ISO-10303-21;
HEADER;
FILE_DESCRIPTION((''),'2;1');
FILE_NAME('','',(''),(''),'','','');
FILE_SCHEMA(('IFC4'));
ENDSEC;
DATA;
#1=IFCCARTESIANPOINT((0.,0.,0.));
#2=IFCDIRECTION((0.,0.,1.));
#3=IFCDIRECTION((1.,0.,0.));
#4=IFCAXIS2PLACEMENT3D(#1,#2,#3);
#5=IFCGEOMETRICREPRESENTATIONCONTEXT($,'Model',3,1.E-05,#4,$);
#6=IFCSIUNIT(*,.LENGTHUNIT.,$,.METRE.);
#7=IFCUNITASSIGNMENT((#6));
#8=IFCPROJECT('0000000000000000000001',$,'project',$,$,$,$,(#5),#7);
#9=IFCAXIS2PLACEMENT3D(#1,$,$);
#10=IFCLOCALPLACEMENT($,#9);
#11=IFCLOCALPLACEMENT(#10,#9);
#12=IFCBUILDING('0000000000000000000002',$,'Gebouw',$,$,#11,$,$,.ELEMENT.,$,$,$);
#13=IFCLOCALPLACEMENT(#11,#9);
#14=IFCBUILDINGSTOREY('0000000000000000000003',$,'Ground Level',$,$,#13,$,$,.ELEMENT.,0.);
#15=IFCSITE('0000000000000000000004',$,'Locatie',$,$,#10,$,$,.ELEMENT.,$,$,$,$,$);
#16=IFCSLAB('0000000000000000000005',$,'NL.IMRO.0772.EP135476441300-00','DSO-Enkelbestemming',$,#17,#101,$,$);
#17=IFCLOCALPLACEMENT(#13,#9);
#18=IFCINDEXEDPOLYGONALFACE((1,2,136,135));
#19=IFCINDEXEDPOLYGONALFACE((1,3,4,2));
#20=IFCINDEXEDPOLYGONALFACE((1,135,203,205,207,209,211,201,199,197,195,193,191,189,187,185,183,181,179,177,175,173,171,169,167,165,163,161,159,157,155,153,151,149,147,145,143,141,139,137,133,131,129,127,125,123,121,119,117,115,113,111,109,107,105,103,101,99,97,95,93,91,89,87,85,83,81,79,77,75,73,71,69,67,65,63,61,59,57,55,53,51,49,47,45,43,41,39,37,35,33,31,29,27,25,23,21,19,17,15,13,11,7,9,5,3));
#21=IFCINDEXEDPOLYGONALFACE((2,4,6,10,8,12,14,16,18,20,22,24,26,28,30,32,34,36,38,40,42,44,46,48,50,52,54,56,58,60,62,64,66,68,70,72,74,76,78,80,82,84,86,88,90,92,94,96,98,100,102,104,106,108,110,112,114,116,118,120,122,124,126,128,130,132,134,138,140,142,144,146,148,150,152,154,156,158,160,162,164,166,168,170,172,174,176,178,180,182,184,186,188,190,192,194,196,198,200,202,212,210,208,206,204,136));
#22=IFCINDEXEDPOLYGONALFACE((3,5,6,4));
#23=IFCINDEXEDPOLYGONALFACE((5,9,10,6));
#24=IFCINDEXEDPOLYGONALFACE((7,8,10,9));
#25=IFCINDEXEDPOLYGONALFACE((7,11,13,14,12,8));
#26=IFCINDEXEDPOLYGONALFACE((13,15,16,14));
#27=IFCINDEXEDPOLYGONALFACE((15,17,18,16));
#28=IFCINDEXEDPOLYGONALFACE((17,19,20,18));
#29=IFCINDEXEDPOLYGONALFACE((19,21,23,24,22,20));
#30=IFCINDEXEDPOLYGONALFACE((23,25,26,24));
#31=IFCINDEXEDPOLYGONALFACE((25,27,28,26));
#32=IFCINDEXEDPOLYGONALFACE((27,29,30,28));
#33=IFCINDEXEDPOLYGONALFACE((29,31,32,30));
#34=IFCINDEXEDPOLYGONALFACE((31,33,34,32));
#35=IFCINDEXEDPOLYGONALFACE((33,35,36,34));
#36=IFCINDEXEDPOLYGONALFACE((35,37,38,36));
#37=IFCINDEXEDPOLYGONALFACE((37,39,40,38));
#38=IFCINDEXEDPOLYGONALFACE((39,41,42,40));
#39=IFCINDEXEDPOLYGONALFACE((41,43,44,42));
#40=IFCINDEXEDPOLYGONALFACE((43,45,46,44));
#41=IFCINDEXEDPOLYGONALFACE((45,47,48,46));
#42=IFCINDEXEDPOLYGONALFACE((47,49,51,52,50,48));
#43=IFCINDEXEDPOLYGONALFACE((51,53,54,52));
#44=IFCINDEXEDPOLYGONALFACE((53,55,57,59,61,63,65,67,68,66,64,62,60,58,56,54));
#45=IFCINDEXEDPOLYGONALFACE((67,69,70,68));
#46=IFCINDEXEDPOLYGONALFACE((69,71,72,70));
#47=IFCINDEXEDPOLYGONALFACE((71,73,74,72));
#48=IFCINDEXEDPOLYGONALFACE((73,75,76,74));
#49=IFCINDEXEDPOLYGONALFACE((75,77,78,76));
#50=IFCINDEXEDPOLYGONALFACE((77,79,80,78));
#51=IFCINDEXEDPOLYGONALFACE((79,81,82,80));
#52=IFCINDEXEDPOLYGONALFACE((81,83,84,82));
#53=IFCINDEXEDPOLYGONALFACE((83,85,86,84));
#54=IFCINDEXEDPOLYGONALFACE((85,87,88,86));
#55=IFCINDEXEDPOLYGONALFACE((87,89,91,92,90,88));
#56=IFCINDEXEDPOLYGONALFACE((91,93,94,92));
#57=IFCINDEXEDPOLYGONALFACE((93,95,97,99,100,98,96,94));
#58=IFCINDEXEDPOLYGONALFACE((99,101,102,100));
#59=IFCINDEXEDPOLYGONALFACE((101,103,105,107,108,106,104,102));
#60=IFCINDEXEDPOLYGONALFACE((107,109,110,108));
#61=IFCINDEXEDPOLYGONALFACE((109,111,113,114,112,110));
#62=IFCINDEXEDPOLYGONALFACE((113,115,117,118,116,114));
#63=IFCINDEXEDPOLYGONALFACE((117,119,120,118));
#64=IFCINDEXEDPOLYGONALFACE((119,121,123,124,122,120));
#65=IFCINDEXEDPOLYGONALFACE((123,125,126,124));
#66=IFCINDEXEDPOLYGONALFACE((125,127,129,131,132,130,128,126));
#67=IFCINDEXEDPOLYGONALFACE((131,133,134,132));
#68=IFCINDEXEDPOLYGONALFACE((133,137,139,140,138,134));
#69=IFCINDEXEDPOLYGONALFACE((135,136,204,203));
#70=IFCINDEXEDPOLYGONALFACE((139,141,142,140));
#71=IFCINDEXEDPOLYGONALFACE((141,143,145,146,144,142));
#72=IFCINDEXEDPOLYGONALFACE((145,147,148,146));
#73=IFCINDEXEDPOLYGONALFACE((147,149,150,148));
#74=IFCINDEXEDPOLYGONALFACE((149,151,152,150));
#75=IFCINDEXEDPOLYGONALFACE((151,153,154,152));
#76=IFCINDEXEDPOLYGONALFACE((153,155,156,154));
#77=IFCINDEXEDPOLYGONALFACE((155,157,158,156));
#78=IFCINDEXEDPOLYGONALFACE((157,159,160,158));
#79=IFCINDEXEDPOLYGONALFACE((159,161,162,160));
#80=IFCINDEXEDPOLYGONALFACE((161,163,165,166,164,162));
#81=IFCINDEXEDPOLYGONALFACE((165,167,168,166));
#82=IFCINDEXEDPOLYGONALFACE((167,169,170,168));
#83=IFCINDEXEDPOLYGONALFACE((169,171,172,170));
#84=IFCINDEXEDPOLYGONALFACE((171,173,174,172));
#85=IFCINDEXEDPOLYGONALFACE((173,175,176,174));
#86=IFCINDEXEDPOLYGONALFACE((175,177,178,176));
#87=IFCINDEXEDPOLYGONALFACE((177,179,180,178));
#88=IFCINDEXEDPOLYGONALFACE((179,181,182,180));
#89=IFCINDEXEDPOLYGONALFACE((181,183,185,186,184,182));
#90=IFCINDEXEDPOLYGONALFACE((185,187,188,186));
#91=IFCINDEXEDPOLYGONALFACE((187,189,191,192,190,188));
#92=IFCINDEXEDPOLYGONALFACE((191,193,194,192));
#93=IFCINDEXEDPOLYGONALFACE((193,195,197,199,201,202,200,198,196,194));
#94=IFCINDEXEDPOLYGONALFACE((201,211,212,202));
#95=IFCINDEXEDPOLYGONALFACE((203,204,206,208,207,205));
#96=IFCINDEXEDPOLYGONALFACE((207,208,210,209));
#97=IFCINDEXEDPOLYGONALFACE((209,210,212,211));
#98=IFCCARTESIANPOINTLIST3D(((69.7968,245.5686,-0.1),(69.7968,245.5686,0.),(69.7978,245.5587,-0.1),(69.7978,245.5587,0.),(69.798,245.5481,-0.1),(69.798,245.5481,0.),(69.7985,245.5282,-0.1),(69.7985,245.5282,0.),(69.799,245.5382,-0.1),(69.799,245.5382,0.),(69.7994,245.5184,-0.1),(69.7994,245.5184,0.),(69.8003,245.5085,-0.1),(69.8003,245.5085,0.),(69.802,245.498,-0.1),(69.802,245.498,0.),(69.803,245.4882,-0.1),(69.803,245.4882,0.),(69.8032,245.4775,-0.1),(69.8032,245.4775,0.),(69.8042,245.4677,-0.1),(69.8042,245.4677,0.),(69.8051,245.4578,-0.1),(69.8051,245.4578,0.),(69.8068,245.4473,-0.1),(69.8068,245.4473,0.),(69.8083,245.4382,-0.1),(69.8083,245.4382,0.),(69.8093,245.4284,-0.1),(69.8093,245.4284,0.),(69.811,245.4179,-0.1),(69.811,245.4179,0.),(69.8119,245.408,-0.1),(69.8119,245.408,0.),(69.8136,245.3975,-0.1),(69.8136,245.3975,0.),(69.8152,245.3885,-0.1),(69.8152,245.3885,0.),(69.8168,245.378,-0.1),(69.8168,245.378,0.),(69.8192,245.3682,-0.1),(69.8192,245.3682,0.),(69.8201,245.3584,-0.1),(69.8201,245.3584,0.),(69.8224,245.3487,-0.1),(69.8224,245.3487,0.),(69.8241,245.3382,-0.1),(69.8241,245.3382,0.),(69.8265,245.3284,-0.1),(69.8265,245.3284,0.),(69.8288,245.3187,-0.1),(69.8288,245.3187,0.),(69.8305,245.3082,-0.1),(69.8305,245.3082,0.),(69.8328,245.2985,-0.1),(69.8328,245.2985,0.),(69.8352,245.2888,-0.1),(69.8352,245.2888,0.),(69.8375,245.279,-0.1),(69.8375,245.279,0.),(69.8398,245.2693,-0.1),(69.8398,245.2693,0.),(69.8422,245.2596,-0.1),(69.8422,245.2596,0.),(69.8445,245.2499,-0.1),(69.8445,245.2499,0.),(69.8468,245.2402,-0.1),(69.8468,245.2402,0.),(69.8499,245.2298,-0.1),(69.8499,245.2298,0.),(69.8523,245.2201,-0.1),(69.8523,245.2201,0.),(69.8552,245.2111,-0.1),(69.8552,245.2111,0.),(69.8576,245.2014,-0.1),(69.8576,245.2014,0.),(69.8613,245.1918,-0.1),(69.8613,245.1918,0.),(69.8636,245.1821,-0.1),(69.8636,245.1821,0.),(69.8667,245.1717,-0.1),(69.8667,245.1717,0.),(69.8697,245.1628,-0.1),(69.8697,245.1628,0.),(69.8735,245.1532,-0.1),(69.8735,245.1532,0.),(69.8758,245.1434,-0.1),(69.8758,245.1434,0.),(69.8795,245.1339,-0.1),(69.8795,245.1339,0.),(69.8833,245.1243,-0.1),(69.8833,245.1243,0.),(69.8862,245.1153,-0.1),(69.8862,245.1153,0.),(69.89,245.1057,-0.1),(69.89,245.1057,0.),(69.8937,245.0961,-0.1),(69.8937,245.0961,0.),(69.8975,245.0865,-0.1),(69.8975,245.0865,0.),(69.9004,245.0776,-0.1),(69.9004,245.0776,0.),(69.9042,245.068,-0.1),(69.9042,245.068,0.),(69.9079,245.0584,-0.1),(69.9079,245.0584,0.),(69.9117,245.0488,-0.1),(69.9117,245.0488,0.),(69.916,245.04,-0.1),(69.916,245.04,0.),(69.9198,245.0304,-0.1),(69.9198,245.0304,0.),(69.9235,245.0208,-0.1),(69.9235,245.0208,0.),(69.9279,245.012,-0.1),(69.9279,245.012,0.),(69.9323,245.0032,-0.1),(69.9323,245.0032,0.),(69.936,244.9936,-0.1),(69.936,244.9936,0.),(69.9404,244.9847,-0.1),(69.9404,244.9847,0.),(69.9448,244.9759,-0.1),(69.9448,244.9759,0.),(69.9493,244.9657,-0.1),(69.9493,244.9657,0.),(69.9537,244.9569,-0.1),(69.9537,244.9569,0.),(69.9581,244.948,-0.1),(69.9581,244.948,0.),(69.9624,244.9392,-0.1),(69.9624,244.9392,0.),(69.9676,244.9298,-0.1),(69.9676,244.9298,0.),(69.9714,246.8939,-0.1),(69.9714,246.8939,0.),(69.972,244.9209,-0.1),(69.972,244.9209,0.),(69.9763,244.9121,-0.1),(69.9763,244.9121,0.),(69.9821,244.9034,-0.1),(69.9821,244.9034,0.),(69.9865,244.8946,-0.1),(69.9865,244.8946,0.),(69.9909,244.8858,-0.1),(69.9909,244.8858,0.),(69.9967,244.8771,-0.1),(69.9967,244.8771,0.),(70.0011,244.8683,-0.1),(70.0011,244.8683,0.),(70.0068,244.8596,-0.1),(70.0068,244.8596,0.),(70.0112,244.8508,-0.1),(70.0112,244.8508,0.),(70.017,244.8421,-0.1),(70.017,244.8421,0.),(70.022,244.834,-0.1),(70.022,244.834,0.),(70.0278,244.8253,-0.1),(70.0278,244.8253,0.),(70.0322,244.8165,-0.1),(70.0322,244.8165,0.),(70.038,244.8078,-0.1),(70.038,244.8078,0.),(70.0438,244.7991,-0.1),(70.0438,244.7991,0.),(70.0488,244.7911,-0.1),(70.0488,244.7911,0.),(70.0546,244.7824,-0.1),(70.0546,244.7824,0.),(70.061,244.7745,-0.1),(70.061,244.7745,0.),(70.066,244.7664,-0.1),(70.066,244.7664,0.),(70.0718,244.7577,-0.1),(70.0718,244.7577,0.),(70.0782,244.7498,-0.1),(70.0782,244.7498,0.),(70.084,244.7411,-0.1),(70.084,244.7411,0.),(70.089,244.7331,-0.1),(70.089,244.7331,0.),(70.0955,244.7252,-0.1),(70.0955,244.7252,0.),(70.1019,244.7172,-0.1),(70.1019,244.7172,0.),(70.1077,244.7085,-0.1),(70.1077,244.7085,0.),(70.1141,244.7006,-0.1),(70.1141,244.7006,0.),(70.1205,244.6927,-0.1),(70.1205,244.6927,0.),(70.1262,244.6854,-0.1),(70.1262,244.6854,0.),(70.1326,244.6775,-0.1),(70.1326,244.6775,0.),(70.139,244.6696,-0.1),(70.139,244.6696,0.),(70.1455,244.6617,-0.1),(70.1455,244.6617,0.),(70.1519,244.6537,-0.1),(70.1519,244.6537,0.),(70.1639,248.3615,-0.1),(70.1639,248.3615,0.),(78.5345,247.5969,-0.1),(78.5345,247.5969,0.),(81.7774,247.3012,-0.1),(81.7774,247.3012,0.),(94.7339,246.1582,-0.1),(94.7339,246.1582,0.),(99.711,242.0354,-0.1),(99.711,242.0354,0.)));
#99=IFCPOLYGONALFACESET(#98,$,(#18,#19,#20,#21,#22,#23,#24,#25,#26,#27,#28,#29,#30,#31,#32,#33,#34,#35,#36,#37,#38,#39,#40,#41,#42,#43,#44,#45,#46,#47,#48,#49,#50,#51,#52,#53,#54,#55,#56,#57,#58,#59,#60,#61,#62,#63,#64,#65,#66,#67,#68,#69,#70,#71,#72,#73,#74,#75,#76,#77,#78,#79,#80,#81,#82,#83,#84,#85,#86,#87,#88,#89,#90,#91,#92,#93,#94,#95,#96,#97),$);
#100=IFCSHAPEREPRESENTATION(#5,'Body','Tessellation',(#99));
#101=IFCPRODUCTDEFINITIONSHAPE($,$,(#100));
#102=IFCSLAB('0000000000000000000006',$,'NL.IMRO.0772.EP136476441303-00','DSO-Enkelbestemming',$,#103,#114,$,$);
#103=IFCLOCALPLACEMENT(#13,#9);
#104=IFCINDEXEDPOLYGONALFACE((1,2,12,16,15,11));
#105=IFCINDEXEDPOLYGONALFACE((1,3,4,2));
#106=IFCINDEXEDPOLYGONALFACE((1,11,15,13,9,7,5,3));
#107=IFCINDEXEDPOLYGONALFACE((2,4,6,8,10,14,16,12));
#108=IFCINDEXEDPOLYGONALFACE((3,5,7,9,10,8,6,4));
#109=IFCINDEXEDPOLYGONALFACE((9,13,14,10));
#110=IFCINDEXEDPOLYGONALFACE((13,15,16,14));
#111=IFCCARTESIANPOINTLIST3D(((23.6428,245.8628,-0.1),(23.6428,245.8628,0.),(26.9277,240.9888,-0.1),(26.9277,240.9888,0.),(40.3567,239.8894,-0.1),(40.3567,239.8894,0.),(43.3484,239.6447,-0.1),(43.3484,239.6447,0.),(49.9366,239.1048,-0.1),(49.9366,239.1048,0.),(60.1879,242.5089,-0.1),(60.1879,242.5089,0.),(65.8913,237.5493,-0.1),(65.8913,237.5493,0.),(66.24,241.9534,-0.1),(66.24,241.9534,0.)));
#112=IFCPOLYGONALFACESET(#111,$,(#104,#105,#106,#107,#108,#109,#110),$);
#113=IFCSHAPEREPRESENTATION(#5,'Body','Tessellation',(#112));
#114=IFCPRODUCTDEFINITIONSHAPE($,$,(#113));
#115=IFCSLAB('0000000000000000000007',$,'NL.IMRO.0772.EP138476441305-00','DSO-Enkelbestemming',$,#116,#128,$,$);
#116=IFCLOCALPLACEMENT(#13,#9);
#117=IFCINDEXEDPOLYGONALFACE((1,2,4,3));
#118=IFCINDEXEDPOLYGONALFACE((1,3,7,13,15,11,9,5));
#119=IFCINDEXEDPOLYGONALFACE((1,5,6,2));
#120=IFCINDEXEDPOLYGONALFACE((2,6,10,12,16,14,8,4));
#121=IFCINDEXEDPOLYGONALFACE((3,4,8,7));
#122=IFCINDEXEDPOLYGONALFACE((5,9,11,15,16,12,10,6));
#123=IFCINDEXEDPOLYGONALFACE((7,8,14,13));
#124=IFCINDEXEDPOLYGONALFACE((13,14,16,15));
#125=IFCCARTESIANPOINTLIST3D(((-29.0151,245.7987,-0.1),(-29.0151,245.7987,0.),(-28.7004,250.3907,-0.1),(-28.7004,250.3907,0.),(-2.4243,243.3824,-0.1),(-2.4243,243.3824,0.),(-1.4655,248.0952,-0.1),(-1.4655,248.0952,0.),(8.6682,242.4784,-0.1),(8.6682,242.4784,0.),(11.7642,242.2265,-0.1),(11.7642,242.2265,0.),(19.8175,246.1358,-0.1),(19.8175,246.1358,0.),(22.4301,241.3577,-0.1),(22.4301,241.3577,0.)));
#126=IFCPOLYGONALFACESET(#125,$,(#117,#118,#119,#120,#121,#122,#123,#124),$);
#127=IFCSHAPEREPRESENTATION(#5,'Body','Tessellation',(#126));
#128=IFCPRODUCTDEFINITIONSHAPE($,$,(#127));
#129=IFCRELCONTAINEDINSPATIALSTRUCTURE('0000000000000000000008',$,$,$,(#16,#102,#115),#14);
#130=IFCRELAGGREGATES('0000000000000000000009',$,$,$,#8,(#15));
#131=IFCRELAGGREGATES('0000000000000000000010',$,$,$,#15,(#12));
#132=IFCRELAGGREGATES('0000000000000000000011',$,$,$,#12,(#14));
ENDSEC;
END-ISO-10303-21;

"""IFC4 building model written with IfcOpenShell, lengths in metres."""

from ifc_helpers import new_model, si_unit, frame, origin, origin_with_axes, place, context, project, spatial, polyline, outline, extrude, element, save


model = new_model("IFC4")

# Units and contexts
model_context = context("Model", 3, precision=1e-05, world=origin_with_axes())
ifc_project = project(units=[si_unit("LENGTHUNIT", "METRE")], contexts=[model_context])

# Site, building, storey
site_placement = place(None, origin())
site = spatial("IfcSite", under=ifc_project, at=site_placement, Name="Locatie", CompositionType="ELEMENT")
building_placement = place(site_placement, origin())
building = spatial("IfcBuilding", under=site, at=building_placement, Name="Gebouw", CompositionType="ELEMENT")
storey_placement = place(building_placement, origin())
storey = spatial("IfcBuildingStorey", under=building, at=storey_placement, Name="Ground Level", CompositionType="ELEMENT", Elevation=0.0)

# Slabs
slab_1_placement = place(storey_placement, origin())
element("IfcSlab", 1, at=slab_1_placement, inside=storey, Name="NL.IMRO.0772.EP135476441300-00", Description="DSO-Enkelbestemming", context=model_context, shape_type="SweptSolid", body=[
    extrude(outline(polyline([(70.1519, 244.6537), (70.1455, 244.6617), (70.139, 244.6696), (70.1326, 244.6775), (70.1262, 244.6854), (70.1205, 244.6927), (70.1141, 244.7006), (70.1077, 244.7085), (70.1019, 244.7172), (70.0955, 244.7252), (70.089, 244.7331), (70.084, 244.7411), (70.0782, 244.7498), (70.0718, 244.7577), (70.066, 244.7664), (70.061, 244.7745), (70.0546, 244.7824), (70.0488, 244.7911), (70.0438, 244.7991), (70.038, 244.8078), (70.0322, 244.8165), (70.0278, 244.8253), (70.022, 244.834), (70.017, 244.8421), (70.0112, 244.8508), (70.0068, 244.8596), (70.0011, 244.8683), (69.9967, 244.8771), (69.9909, 244.8858), (69.9865, 244.8946), (69.9821, 244.9034), (69.9763, 244.9121), (69.972, 244.9209), (69.9676, 244.9298), (69.9624, 244.9392), (69.9581, 244.948), (69.9537, 244.9569), (69.9493, 244.9657), (69.9448, 244.9759), (69.9404, 244.9847), (69.936, 244.9936), (69.9323, 245.0032), (69.9279, 245.012), (69.9235, 245.0208), (69.9198, 245.0304), (69.916, 245.04), (69.9117, 245.0488), (69.9079, 245.0584), (69.9042, 245.068), (69.9004, 245.0776), (69.8975, 245.0865), (69.8937, 245.0961), (69.89, 245.1057), (69.8862, 245.1153), (69.8833, 245.1243), (69.8795, 245.1339), (69.8758, 245.1434), (69.8735, 245.1532), (69.8697, 245.1628), (69.8667, 245.1717), (69.8636, 245.1821), (69.8613, 245.1918), (69.8576, 245.2014), (69.8552, 245.2111), (69.8523, 245.2201), (69.8499, 245.2298), (69.8468, 245.2402), (69.8445, 245.2499), (69.8422, 245.2596), (69.8398, 245.2693), (69.8375, 245.279), (69.8352, 245.2888), (69.8328, 245.2985), (69.8305, 245.3082), (69.8288, 245.3187), (69.8265, 245.3284), (69.8241, 245.3382), (69.8224, 245.3487), (69.8201, 245.3584), (69.8192, 245.3682), (69.8168, 245.378), (69.8152, 245.3885), (69.8136, 245.3975), (69.8119, 245.408), (69.811, 245.4179), (69.8093, 245.4284), (69.8083, 245.4382), (69.8068, 245.4473), (69.8051, 245.4578), (69.8042, 245.4677), (69.8032, 245.4775), (69.803, 245.4882), (69.802, 245.498), (69.8003, 245.5085), (69.7994, 245.5184), (69.7985, 245.5282), (69.799, 245.5382), (69.798, 245.5481), (69.7978, 245.5587), (69.7968, 245.5686), (69.9714, 246.8939), (70.1639, 248.3615), (78.5345, 247.5969), (81.7774, 247.3012), (94.7339, 246.1582), (99.711, 242.0354), (70.1519, 244.6537)])), frame((0.0, 0.0, -0.1), z_axis=(0.0, 0.0, 1.0), x_axis=(1.0, 0.0, 0.0)), (0.0, 0.0, 1.0), 0.1),
])
slab_2_placement = place(storey_placement, origin())
element("IfcSlab", 2, at=slab_2_placement, inside=storey, Name="NL.IMRO.0772.EP136476441303-00", Description="DSO-Enkelbestemming", context=model_context, shape_type="SweptSolid", body=[
    extrude(outline(polyline([(65.8913, 237.5493), (49.9366, 239.1048), (43.3484, 239.6447), (40.3567, 239.8894), (26.9277, 240.9888), (23.6428, 245.8628), (60.1879, 242.5089), (66.24, 241.9534), (65.8913, 237.5493)])), frame((0.0, 0.0, -0.1), z_axis=(0.0, 0.0, 1.0), x_axis=(1.0, 0.0, 0.0)), (0.0, 0.0, 1.0), 0.1),
])
slab_3_placement = place(storey_placement, origin())
element("IfcSlab", 3, at=slab_3_placement, inside=storey, Name="NL.IMRO.0772.EP138476441305-00", Description="DSO-Enkelbestemming", context=model_context, shape_type="SweptSolid", body=[
    extrude(outline(polyline([(-2.4243, 243.3824), (-29.0151, 245.7987), (-28.7004, 250.3907), (-1.4655, 248.0952), (19.8175, 246.1358), (22.4301, 241.3577), (11.7642, 242.2265), (8.6682, 242.4784), (-2.4243, 243.3824)])), frame((0.0, 0.0, -0.1), z_axis=(0.0, 0.0, 1.0), x_axis=(1.0, 0.0, 0.0)), (0.0, 0.0, 1.0), 0.1),
])

save(model, "model.ifc")
